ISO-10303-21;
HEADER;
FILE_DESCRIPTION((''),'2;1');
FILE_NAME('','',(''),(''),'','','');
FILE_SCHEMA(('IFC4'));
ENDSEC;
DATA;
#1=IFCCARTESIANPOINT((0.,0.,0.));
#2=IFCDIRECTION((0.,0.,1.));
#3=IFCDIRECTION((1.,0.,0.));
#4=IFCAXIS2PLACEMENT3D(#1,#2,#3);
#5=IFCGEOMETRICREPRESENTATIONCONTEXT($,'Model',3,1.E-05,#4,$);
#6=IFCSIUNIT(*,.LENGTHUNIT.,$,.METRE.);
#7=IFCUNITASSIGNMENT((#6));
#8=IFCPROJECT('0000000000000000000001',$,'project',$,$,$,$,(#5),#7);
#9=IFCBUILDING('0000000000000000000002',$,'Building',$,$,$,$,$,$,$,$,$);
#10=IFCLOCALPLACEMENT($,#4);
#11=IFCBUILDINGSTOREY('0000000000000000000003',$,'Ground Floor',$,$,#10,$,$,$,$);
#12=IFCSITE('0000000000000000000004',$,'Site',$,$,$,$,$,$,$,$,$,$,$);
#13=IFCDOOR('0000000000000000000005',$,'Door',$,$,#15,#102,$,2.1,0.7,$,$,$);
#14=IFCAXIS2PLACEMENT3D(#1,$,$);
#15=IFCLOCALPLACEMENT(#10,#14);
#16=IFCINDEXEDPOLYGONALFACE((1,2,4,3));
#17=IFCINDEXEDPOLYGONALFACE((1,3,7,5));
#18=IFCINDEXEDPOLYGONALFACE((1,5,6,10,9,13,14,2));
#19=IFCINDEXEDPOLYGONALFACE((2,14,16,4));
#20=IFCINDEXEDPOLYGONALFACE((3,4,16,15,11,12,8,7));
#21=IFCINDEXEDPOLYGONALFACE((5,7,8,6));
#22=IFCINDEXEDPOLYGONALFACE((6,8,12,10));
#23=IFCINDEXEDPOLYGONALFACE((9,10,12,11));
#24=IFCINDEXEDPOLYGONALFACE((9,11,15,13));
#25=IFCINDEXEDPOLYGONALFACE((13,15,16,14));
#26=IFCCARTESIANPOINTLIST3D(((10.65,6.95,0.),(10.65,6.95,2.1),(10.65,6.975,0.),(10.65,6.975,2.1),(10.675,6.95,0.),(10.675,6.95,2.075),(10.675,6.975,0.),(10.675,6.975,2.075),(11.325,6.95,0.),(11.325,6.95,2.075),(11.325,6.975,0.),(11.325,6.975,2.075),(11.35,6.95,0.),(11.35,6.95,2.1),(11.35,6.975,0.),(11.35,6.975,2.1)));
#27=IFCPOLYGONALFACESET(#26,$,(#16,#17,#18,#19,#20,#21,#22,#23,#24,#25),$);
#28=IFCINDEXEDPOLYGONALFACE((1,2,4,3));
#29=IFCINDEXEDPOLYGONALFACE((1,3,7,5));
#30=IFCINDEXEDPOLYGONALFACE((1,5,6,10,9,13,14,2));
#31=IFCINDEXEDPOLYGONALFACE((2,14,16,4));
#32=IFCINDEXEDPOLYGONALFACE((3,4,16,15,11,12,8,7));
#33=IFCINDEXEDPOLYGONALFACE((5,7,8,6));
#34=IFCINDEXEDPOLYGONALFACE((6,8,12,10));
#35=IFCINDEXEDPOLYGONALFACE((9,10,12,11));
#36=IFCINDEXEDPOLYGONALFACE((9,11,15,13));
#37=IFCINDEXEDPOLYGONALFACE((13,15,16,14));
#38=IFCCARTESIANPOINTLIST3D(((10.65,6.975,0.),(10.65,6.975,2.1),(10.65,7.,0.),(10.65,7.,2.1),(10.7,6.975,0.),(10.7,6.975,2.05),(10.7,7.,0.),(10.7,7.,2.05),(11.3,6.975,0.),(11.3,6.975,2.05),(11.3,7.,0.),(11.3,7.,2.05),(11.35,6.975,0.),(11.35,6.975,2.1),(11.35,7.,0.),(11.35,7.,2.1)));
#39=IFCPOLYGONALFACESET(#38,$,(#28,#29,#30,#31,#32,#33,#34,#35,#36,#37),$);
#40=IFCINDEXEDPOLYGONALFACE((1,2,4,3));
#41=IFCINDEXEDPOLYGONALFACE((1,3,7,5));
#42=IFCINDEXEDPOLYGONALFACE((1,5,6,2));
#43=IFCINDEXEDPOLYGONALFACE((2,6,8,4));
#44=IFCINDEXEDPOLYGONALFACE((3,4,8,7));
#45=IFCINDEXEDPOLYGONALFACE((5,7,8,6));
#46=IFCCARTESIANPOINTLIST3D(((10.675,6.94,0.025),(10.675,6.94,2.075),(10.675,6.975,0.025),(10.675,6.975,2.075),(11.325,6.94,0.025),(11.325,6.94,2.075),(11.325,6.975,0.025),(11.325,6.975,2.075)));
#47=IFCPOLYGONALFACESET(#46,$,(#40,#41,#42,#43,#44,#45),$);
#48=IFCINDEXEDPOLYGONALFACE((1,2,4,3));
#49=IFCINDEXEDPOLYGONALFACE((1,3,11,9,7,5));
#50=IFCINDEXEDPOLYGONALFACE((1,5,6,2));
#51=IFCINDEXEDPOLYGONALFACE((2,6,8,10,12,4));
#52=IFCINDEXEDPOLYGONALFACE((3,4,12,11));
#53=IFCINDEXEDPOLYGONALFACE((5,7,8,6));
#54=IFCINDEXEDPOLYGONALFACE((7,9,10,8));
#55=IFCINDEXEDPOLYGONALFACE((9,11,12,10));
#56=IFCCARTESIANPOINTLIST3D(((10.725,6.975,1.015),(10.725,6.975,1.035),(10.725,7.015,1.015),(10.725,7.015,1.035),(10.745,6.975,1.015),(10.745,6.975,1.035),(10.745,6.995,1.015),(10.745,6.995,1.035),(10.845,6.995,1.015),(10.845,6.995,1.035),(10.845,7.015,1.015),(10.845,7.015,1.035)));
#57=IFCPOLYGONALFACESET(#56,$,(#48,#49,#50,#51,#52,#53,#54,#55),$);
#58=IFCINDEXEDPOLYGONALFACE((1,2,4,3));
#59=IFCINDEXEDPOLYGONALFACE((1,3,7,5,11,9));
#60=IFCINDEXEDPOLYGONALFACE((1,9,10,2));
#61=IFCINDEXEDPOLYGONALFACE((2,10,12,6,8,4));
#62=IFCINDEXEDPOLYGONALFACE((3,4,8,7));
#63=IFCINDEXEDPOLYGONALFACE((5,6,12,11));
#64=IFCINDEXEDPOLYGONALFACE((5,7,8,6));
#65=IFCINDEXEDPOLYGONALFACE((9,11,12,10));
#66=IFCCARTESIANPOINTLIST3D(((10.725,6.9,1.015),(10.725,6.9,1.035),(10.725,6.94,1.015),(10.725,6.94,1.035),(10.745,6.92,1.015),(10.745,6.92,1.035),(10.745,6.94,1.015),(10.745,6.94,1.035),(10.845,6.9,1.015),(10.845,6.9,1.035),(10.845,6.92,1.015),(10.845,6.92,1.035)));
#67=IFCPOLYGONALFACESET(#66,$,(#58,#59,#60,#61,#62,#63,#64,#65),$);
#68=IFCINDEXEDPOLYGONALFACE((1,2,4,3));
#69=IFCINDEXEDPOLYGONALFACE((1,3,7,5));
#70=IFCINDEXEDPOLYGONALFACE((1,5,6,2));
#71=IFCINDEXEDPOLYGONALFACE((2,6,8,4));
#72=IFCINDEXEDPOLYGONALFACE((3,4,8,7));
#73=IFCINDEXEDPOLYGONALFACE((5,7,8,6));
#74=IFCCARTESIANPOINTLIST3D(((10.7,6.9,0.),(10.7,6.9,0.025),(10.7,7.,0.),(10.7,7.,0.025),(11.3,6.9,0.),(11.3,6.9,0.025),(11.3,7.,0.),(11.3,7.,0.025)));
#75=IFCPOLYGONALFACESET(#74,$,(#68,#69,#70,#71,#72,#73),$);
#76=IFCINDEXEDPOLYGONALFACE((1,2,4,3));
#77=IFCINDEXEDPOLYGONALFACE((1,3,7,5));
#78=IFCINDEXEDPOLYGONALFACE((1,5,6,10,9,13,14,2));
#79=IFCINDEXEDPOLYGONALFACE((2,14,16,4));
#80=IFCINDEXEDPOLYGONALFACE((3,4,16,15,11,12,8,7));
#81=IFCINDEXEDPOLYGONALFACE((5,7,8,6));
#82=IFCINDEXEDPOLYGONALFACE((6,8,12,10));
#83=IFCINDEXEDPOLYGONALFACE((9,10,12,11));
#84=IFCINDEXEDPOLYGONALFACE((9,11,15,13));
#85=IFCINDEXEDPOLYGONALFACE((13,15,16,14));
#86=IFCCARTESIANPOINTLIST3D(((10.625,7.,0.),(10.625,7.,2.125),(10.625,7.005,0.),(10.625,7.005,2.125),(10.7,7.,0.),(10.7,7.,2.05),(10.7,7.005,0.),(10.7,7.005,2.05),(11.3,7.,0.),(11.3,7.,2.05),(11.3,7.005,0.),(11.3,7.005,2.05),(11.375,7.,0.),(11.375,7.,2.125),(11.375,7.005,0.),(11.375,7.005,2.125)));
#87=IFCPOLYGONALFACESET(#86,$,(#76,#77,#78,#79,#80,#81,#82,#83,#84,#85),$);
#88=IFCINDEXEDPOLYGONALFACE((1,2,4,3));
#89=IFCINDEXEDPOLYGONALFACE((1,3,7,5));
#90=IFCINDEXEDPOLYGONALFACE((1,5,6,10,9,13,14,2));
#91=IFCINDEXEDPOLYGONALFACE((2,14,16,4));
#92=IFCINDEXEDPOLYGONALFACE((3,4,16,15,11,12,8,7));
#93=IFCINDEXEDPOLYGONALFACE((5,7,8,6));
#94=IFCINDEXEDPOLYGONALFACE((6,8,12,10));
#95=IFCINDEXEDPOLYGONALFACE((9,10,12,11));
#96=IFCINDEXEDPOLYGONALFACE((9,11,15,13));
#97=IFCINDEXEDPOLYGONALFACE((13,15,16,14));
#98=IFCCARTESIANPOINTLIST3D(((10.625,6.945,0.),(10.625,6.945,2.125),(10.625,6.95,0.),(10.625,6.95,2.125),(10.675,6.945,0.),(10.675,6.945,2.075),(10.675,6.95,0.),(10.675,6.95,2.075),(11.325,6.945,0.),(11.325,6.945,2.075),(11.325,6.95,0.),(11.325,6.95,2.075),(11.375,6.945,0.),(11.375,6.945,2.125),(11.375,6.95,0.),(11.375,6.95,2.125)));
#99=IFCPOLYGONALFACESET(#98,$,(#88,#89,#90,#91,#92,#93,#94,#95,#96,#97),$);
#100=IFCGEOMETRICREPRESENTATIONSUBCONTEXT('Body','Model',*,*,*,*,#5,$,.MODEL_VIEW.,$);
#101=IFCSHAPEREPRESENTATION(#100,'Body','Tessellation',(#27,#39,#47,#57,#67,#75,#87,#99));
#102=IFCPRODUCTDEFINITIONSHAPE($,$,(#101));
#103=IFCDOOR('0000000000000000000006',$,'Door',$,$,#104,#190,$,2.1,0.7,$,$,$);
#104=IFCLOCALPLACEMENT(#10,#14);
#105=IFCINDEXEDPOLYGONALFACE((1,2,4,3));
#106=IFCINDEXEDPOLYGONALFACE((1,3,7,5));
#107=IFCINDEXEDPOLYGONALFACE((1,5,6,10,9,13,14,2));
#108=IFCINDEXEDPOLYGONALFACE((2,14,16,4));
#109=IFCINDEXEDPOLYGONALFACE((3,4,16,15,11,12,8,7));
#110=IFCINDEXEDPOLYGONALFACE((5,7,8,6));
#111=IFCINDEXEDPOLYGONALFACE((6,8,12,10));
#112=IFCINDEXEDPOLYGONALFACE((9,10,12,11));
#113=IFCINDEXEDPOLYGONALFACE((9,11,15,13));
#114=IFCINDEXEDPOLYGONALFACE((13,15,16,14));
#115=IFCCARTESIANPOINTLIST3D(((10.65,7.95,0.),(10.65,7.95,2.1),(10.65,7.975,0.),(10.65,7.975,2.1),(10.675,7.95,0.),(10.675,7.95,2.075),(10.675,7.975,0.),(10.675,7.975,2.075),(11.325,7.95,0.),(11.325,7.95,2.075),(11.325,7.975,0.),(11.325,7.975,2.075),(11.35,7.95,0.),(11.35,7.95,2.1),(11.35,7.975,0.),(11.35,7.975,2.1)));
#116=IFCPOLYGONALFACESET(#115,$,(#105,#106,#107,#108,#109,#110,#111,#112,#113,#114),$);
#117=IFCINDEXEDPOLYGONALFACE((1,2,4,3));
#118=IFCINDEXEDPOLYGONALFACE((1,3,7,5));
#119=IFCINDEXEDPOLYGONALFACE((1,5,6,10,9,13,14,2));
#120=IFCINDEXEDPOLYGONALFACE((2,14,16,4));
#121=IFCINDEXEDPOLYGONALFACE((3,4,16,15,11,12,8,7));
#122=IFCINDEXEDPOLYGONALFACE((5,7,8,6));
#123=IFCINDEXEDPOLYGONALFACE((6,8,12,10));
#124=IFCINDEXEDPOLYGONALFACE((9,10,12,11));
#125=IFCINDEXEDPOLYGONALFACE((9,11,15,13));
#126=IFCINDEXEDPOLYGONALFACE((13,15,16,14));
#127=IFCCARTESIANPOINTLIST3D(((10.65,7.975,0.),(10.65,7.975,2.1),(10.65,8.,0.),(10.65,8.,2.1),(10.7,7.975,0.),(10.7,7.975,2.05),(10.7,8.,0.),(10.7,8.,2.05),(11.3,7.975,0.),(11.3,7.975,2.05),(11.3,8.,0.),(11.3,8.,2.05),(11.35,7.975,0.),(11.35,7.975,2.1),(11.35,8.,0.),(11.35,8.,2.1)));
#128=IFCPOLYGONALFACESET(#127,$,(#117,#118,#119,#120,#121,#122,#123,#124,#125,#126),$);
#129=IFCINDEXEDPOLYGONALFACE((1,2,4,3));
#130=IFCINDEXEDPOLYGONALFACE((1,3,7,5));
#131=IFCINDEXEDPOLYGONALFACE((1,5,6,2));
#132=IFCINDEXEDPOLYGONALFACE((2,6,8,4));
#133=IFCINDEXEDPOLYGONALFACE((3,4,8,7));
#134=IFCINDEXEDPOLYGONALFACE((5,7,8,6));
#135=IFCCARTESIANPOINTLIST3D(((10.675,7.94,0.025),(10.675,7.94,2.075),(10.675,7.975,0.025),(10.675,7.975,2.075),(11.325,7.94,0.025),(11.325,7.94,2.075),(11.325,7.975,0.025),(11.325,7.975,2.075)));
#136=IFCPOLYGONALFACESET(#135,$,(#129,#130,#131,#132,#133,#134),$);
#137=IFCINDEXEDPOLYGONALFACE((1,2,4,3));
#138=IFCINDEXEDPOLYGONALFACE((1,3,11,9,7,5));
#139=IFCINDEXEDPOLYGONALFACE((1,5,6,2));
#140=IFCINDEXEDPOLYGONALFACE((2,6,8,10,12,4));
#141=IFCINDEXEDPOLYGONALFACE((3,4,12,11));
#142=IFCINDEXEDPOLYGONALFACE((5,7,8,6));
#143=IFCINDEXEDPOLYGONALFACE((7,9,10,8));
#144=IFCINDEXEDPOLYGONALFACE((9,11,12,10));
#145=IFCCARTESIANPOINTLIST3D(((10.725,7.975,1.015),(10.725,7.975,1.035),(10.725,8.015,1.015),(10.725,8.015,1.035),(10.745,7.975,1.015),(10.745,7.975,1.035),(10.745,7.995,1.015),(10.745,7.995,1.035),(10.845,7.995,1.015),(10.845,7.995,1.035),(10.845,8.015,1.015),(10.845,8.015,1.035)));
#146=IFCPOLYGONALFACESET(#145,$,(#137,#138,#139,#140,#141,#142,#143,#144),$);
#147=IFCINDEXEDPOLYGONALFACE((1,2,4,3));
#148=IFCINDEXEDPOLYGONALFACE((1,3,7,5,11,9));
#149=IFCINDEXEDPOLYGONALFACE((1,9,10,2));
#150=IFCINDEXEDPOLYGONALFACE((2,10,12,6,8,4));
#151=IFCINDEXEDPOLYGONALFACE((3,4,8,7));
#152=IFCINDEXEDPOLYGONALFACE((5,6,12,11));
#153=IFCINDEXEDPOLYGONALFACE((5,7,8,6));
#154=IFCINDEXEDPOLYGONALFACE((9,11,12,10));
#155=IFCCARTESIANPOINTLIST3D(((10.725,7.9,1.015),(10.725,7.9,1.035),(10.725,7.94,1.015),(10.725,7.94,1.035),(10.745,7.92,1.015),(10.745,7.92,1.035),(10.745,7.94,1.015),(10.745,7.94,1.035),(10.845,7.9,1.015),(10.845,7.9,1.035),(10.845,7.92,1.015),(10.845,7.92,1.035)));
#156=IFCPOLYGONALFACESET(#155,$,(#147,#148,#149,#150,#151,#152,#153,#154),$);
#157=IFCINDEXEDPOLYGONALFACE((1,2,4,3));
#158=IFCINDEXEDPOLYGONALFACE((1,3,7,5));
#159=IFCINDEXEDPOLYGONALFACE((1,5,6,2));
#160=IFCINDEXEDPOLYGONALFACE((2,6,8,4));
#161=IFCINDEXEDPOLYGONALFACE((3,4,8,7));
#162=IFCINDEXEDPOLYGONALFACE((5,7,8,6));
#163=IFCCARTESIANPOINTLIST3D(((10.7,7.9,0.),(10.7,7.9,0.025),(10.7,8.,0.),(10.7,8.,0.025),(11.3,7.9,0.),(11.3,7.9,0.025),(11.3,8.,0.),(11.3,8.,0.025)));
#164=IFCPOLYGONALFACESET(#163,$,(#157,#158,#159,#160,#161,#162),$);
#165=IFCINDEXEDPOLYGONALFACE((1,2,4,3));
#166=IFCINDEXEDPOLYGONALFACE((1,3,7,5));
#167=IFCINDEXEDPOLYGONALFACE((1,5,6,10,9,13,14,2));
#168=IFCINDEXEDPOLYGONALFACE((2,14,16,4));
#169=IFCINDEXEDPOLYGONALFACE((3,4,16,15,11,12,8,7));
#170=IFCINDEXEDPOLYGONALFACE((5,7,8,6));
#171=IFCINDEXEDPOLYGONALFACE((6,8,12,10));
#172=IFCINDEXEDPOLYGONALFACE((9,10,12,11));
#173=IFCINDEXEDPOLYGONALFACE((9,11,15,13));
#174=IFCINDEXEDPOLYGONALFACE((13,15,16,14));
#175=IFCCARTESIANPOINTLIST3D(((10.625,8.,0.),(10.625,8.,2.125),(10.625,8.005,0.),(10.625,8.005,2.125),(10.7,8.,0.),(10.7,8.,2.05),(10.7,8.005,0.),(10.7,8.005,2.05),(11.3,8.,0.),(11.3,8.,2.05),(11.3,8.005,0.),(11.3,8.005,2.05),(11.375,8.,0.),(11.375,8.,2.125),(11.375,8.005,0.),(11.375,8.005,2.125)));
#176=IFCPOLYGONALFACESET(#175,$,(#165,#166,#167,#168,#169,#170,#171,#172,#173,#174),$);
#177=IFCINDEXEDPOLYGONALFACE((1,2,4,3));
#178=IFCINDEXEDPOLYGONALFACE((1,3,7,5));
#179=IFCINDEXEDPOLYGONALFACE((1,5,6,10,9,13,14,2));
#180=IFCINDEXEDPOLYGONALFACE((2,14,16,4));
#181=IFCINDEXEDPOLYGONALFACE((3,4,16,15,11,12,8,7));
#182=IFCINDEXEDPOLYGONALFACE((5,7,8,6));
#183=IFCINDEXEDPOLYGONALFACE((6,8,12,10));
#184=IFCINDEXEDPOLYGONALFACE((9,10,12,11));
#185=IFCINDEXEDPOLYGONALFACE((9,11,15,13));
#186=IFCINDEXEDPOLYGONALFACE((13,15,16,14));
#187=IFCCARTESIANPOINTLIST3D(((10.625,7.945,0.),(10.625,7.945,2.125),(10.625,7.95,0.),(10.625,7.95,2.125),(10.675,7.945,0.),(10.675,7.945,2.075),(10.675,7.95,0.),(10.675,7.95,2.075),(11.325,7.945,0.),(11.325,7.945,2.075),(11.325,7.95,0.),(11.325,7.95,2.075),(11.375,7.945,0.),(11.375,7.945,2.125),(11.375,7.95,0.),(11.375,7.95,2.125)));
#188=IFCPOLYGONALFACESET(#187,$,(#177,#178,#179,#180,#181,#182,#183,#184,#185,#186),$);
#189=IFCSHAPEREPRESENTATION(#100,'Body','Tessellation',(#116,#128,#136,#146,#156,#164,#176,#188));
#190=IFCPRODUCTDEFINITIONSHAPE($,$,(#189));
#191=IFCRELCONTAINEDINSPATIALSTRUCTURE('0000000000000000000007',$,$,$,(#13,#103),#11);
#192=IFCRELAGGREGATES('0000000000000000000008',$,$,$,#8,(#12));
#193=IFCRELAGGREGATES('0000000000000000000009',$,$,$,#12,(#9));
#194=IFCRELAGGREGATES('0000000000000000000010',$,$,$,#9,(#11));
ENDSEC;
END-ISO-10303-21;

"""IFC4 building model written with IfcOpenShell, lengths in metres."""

from ifc_helpers import new_model, si_unit, frame, origin_with_axes, place, context, subcontext, project, spatial, line, indexed_curve, outline, extrude, element, save


model = new_model("IFC4")

# Units and contexts
model_context = context("Model", 3, precision=1e-05, world=origin_with_axes())
body_context = subcontext(model_context, "Body", "Model", "MODEL_VIEW")
ifc_project = project(units=[si_unit("LENGTHUNIT", "METRE")], contexts=[model_context])

# Site, building, storey
site = spatial("IfcSite", under=ifc_project, Name="Site")
building = spatial("IfcBuilding", under=site, Name="Building")
storey_placement = place(None, origin_with_axes())
storey = spatial("IfcBuildingStorey", under=building, at=storey_placement, Name="Ground Floor")

# Doors
door_1_placement = place(storey_placement, frame((11.35, 7.0, 0.0), z_axis=(0.0, 0.0, 1.0), x_axis=(-1.0, 0.0, 0.0)))
element("IfcDoor", 1, at=door_1_placement, inside=storey, Name="Door", OverallHeight=2.1, OverallWidth=0.7, context=body_context, shape_type="SweptSolid", body=[
    extrude(outline(indexed_curve([(0.0, 0.0), (0.0, 2.1), (0.7, 2.1), (0.7, 0.0), (0.675, 0.0), (0.675, 2.075), (0.025, 2.075), (0.025, 0.0)], segments=[line(1, 2, 3, 4, 5, 6, 7, 8, 1)])), frame((0.0, 0.025, 0.0), z_axis=(0.0, -1.0, 0.0), x_axis=(1.0, 0.0, 0.0)), (0.0, 0.0, -1.0), 0.025),
    extrude(outline(indexed_curve([(0.0, 0.0), (0.0, 2.1), (0.7, 2.1), (0.7, 0.0), (0.65, 0.0), (0.65, 2.05), (0.05, 2.05), (0.05, 0.0)], segments=[line(1, 2, 3, 4, 5, 6, 7, 8, 1)])), frame((0.0, 0.0, 0.0), z_axis=(0.0, -1.0, 0.0), x_axis=(1.0, 0.0, 0.0)), (0.0, 0.0, -1.0), 0.025),
    extrude(outline(indexed_curve([(0.0, 0.0), (0.65, 0.0), (0.65, 0.035), (0.0, 0.035)], segments=[line(1, 2, 3, 4, 1)])), frame((0.025, 0.025, 0.025), z_axis=(0.0, 0.0, 1.0), x_axis=(1.0, 0.0, 0.0)), (0.0, 0.0, 1.0), 2.05),
    extrude(outline(indexed_curve([(0.0, 0.0), (0.0, -0.04), (-0.12, -0.04), (-0.12, -0.02), (-0.02, -0.02), (-0.02, 0.0)], segments=[line(1, 2, 3, 4, 5, 6, 1)])), frame((0.625, 0.025, 1.015), z_axis=(0.0, 0.0, 1.0), x_axis=(1.0, 0.0, 0.0)), (0.0, 0.0, 1.0), 0.02),
    extrude(outline(indexed_curve([(0.0, 0.0), (0.0, 0.04), (-0.12, 0.04), (-0.12, 0.02), (-0.02, 0.02), (-0.02, 0.0)], segments=[line(1, 2, 3, 4, 5, 6, 1)])), frame((0.625, 0.06, 1.015), z_axis=(0.0, 0.0, 1.0), x_axis=(1.0, 0.0, 0.0)), (0.0, 0.0, 1.0), 0.02),
    extrude(outline(indexed_curve([(0.0, 0.0), (0.6, 0.0), (0.6, 0.1), (0.0, 0.1)], segments=[line(1, 2, 3, 4, 1)])), frame((0.05, 0.0, 0.0), z_axis=(0.0, 0.0, 1.0), x_axis=(1.0, 0.0, 0.0)), (0.0, 0.0, 1.0), 0.025),
    extrude(outline(indexed_curve([(0.0, 0.0), (0.0, 2.125), (0.75, 2.125), (0.75, 0.0), (0.675, 0.0), (0.675, 2.05), (0.075, 2.05), (0.075, 0.0)], segments=[line(1, 2, 3, 4, 5, 6, 7, 8, 1)])), frame((-0.025, -0.005, 0.0), z_axis=(0.0, -1.0, 0.0), x_axis=(1.0, 0.0, 0.0)), (0.0, 0.0, -1.0), 0.005),
    extrude(outline(indexed_curve([(0.0, 0.0), (0.0, 2.125), (0.75, 2.125), (0.75, 0.0), (0.7, 0.0), (0.7, 2.075), (0.05, 2.075), (0.05, 0.0)], segments=[line(1, 2, 3, 4, 5, 6, 7, 8, 1)])), frame((-0.025, 0.05, 0.0), z_axis=(0.0, -1.0, 0.0), x_axis=(1.0, 0.0, 0.0)), (0.0, 0.0, -1.0), 0.005),
])
door_2_placement = place(storey_placement, frame((11.35, 8.0, 0.0), z_axis=(0.0, 0.0, 1.0), x_axis=(-1.0, 0.0, 0.0)))
element("IfcDoor", 2, at=door_2_placement, inside=storey, Name="Door", OverallHeight=2.1, OverallWidth=0.7, context=body_context, shape_type="SweptSolid", body=[
    extrude(outline(indexed_curve([(0.0, 0.0), (0.0, 2.1), (0.7, 2.1), (0.7, 0.0), (0.675, 0.0), (0.675, 2.075), (0.025, 2.075), (0.025, 0.0)], segments=[line(1, 2, 3, 4, 5, 6, 7, 8, 1)])), frame((0.0, 0.025, 0.0), z_axis=(0.0, -1.0, 0.0), x_axis=(1.0, 0.0, 0.0)), (0.0, 0.0, -1.0), 0.025),
    extrude(outline(indexed_curve([(0.0, 0.0), (0.0, 2.1), (0.7, 2.1), (0.7, 0.0), (0.65, 0.0), (0.65, 2.05), (0.05, 2.05), (0.05, 0.0)], segments=[line(1, 2, 3, 4, 5, 6, 7, 8, 1)])), frame((0.0, 0.0, 0.0), z_axis=(0.0, -1.0, 0.0), x_axis=(1.0, 0.0, 0.0)), (0.0, 0.0, -1.0), 0.025),
    extrude(outline(indexed_curve([(0.0, 0.0), (0.65, 0.0), (0.65, 0.035), (0.0, 0.035)], segments=[line(1, 2, 3, 4, 1)])), frame((0.025, 0.025, 0.025), z_axis=(0.0, 0.0, 1.0), x_axis=(1.0, 0.0, 0.0)), (0.0, 0.0, 1.0), 2.05),
    extrude(outline(indexed_curve([(0.0, 0.0), (0.0, -0.04), (-0.12, -0.04), (-0.12, -0.02), (-0.02, -0.02), (-0.02, 0.0)], segments=[line(1, 2, 3, 4, 5, 6, 1)])), frame((0.625, 0.025, 1.015), z_axis=(0.0, 0.0, 1.0), x_axis=(1.0, 0.0, 0.0)), (0.0, 0.0, 1.0), 0.02),
    extrude(outline(indexed_curve([(0.0, 0.0), (0.0, 0.04), (-0.12, 0.04), (-0.12, 0.02), (-0.02, 0.02), (-0.02, 0.0)], segments=[line(1, 2, 3, 4, 5, 6, 1)])), frame((0.625, 0.06, 1.015), z_axis=(0.0, 0.0, 1.0), x_axis=(1.0, 0.0, 0.0)), (0.0, 0.0, 1.0), 0.02),
    extrude(outline(indexed_curve([(0.0, 0.0), (0.6, 0.0), (0.6, 0.1), (0.0, 0.1)], segments=[line(1, 2, 3, 4, 1)])), frame((0.05, 0.0, 0.0), z_axis=(0.0, 0.0, 1.0), x_axis=(1.0, 0.0, 0.0)), (0.0, 0.0, 1.0), 0.025),
    extrude(outline(indexed_curve([(0.0, 0.0), (0.0, 2.125), (0.75, 2.125), (0.75, 0.0), (0.675, 0.0), (0.675, 2.05), (0.075, 2.05), (0.075, 0.0)], segments=[line(1, 2, 3, 4, 5, 6, 7, 8, 1)])), frame((-0.025, -0.005, 0.0), z_axis=(0.0, -1.0, 0.0), x_axis=(1.0, 0.0, 0.0)), (0.0, 0.0, -1.0), 0.005),
    extrude(outline(indexed_curve([(0.0, 0.0), (0.0, 2.125), (0.75, 2.125), (0.75, 0.0), (0.7, 0.0), (0.7, 2.075), (0.05, 2.075), (0.05, 0.0)], segments=[line(1, 2, 3, 4, 5, 6, 7, 8, 1)])), frame((-0.025, 0.05, 0.0), z_axis=(0.0, -1.0, 0.0), x_axis=(1.0, 0.0, 0.0)), (0.0, 0.0, -1.0), 0.005),
])

save(model, "model.ifc")
